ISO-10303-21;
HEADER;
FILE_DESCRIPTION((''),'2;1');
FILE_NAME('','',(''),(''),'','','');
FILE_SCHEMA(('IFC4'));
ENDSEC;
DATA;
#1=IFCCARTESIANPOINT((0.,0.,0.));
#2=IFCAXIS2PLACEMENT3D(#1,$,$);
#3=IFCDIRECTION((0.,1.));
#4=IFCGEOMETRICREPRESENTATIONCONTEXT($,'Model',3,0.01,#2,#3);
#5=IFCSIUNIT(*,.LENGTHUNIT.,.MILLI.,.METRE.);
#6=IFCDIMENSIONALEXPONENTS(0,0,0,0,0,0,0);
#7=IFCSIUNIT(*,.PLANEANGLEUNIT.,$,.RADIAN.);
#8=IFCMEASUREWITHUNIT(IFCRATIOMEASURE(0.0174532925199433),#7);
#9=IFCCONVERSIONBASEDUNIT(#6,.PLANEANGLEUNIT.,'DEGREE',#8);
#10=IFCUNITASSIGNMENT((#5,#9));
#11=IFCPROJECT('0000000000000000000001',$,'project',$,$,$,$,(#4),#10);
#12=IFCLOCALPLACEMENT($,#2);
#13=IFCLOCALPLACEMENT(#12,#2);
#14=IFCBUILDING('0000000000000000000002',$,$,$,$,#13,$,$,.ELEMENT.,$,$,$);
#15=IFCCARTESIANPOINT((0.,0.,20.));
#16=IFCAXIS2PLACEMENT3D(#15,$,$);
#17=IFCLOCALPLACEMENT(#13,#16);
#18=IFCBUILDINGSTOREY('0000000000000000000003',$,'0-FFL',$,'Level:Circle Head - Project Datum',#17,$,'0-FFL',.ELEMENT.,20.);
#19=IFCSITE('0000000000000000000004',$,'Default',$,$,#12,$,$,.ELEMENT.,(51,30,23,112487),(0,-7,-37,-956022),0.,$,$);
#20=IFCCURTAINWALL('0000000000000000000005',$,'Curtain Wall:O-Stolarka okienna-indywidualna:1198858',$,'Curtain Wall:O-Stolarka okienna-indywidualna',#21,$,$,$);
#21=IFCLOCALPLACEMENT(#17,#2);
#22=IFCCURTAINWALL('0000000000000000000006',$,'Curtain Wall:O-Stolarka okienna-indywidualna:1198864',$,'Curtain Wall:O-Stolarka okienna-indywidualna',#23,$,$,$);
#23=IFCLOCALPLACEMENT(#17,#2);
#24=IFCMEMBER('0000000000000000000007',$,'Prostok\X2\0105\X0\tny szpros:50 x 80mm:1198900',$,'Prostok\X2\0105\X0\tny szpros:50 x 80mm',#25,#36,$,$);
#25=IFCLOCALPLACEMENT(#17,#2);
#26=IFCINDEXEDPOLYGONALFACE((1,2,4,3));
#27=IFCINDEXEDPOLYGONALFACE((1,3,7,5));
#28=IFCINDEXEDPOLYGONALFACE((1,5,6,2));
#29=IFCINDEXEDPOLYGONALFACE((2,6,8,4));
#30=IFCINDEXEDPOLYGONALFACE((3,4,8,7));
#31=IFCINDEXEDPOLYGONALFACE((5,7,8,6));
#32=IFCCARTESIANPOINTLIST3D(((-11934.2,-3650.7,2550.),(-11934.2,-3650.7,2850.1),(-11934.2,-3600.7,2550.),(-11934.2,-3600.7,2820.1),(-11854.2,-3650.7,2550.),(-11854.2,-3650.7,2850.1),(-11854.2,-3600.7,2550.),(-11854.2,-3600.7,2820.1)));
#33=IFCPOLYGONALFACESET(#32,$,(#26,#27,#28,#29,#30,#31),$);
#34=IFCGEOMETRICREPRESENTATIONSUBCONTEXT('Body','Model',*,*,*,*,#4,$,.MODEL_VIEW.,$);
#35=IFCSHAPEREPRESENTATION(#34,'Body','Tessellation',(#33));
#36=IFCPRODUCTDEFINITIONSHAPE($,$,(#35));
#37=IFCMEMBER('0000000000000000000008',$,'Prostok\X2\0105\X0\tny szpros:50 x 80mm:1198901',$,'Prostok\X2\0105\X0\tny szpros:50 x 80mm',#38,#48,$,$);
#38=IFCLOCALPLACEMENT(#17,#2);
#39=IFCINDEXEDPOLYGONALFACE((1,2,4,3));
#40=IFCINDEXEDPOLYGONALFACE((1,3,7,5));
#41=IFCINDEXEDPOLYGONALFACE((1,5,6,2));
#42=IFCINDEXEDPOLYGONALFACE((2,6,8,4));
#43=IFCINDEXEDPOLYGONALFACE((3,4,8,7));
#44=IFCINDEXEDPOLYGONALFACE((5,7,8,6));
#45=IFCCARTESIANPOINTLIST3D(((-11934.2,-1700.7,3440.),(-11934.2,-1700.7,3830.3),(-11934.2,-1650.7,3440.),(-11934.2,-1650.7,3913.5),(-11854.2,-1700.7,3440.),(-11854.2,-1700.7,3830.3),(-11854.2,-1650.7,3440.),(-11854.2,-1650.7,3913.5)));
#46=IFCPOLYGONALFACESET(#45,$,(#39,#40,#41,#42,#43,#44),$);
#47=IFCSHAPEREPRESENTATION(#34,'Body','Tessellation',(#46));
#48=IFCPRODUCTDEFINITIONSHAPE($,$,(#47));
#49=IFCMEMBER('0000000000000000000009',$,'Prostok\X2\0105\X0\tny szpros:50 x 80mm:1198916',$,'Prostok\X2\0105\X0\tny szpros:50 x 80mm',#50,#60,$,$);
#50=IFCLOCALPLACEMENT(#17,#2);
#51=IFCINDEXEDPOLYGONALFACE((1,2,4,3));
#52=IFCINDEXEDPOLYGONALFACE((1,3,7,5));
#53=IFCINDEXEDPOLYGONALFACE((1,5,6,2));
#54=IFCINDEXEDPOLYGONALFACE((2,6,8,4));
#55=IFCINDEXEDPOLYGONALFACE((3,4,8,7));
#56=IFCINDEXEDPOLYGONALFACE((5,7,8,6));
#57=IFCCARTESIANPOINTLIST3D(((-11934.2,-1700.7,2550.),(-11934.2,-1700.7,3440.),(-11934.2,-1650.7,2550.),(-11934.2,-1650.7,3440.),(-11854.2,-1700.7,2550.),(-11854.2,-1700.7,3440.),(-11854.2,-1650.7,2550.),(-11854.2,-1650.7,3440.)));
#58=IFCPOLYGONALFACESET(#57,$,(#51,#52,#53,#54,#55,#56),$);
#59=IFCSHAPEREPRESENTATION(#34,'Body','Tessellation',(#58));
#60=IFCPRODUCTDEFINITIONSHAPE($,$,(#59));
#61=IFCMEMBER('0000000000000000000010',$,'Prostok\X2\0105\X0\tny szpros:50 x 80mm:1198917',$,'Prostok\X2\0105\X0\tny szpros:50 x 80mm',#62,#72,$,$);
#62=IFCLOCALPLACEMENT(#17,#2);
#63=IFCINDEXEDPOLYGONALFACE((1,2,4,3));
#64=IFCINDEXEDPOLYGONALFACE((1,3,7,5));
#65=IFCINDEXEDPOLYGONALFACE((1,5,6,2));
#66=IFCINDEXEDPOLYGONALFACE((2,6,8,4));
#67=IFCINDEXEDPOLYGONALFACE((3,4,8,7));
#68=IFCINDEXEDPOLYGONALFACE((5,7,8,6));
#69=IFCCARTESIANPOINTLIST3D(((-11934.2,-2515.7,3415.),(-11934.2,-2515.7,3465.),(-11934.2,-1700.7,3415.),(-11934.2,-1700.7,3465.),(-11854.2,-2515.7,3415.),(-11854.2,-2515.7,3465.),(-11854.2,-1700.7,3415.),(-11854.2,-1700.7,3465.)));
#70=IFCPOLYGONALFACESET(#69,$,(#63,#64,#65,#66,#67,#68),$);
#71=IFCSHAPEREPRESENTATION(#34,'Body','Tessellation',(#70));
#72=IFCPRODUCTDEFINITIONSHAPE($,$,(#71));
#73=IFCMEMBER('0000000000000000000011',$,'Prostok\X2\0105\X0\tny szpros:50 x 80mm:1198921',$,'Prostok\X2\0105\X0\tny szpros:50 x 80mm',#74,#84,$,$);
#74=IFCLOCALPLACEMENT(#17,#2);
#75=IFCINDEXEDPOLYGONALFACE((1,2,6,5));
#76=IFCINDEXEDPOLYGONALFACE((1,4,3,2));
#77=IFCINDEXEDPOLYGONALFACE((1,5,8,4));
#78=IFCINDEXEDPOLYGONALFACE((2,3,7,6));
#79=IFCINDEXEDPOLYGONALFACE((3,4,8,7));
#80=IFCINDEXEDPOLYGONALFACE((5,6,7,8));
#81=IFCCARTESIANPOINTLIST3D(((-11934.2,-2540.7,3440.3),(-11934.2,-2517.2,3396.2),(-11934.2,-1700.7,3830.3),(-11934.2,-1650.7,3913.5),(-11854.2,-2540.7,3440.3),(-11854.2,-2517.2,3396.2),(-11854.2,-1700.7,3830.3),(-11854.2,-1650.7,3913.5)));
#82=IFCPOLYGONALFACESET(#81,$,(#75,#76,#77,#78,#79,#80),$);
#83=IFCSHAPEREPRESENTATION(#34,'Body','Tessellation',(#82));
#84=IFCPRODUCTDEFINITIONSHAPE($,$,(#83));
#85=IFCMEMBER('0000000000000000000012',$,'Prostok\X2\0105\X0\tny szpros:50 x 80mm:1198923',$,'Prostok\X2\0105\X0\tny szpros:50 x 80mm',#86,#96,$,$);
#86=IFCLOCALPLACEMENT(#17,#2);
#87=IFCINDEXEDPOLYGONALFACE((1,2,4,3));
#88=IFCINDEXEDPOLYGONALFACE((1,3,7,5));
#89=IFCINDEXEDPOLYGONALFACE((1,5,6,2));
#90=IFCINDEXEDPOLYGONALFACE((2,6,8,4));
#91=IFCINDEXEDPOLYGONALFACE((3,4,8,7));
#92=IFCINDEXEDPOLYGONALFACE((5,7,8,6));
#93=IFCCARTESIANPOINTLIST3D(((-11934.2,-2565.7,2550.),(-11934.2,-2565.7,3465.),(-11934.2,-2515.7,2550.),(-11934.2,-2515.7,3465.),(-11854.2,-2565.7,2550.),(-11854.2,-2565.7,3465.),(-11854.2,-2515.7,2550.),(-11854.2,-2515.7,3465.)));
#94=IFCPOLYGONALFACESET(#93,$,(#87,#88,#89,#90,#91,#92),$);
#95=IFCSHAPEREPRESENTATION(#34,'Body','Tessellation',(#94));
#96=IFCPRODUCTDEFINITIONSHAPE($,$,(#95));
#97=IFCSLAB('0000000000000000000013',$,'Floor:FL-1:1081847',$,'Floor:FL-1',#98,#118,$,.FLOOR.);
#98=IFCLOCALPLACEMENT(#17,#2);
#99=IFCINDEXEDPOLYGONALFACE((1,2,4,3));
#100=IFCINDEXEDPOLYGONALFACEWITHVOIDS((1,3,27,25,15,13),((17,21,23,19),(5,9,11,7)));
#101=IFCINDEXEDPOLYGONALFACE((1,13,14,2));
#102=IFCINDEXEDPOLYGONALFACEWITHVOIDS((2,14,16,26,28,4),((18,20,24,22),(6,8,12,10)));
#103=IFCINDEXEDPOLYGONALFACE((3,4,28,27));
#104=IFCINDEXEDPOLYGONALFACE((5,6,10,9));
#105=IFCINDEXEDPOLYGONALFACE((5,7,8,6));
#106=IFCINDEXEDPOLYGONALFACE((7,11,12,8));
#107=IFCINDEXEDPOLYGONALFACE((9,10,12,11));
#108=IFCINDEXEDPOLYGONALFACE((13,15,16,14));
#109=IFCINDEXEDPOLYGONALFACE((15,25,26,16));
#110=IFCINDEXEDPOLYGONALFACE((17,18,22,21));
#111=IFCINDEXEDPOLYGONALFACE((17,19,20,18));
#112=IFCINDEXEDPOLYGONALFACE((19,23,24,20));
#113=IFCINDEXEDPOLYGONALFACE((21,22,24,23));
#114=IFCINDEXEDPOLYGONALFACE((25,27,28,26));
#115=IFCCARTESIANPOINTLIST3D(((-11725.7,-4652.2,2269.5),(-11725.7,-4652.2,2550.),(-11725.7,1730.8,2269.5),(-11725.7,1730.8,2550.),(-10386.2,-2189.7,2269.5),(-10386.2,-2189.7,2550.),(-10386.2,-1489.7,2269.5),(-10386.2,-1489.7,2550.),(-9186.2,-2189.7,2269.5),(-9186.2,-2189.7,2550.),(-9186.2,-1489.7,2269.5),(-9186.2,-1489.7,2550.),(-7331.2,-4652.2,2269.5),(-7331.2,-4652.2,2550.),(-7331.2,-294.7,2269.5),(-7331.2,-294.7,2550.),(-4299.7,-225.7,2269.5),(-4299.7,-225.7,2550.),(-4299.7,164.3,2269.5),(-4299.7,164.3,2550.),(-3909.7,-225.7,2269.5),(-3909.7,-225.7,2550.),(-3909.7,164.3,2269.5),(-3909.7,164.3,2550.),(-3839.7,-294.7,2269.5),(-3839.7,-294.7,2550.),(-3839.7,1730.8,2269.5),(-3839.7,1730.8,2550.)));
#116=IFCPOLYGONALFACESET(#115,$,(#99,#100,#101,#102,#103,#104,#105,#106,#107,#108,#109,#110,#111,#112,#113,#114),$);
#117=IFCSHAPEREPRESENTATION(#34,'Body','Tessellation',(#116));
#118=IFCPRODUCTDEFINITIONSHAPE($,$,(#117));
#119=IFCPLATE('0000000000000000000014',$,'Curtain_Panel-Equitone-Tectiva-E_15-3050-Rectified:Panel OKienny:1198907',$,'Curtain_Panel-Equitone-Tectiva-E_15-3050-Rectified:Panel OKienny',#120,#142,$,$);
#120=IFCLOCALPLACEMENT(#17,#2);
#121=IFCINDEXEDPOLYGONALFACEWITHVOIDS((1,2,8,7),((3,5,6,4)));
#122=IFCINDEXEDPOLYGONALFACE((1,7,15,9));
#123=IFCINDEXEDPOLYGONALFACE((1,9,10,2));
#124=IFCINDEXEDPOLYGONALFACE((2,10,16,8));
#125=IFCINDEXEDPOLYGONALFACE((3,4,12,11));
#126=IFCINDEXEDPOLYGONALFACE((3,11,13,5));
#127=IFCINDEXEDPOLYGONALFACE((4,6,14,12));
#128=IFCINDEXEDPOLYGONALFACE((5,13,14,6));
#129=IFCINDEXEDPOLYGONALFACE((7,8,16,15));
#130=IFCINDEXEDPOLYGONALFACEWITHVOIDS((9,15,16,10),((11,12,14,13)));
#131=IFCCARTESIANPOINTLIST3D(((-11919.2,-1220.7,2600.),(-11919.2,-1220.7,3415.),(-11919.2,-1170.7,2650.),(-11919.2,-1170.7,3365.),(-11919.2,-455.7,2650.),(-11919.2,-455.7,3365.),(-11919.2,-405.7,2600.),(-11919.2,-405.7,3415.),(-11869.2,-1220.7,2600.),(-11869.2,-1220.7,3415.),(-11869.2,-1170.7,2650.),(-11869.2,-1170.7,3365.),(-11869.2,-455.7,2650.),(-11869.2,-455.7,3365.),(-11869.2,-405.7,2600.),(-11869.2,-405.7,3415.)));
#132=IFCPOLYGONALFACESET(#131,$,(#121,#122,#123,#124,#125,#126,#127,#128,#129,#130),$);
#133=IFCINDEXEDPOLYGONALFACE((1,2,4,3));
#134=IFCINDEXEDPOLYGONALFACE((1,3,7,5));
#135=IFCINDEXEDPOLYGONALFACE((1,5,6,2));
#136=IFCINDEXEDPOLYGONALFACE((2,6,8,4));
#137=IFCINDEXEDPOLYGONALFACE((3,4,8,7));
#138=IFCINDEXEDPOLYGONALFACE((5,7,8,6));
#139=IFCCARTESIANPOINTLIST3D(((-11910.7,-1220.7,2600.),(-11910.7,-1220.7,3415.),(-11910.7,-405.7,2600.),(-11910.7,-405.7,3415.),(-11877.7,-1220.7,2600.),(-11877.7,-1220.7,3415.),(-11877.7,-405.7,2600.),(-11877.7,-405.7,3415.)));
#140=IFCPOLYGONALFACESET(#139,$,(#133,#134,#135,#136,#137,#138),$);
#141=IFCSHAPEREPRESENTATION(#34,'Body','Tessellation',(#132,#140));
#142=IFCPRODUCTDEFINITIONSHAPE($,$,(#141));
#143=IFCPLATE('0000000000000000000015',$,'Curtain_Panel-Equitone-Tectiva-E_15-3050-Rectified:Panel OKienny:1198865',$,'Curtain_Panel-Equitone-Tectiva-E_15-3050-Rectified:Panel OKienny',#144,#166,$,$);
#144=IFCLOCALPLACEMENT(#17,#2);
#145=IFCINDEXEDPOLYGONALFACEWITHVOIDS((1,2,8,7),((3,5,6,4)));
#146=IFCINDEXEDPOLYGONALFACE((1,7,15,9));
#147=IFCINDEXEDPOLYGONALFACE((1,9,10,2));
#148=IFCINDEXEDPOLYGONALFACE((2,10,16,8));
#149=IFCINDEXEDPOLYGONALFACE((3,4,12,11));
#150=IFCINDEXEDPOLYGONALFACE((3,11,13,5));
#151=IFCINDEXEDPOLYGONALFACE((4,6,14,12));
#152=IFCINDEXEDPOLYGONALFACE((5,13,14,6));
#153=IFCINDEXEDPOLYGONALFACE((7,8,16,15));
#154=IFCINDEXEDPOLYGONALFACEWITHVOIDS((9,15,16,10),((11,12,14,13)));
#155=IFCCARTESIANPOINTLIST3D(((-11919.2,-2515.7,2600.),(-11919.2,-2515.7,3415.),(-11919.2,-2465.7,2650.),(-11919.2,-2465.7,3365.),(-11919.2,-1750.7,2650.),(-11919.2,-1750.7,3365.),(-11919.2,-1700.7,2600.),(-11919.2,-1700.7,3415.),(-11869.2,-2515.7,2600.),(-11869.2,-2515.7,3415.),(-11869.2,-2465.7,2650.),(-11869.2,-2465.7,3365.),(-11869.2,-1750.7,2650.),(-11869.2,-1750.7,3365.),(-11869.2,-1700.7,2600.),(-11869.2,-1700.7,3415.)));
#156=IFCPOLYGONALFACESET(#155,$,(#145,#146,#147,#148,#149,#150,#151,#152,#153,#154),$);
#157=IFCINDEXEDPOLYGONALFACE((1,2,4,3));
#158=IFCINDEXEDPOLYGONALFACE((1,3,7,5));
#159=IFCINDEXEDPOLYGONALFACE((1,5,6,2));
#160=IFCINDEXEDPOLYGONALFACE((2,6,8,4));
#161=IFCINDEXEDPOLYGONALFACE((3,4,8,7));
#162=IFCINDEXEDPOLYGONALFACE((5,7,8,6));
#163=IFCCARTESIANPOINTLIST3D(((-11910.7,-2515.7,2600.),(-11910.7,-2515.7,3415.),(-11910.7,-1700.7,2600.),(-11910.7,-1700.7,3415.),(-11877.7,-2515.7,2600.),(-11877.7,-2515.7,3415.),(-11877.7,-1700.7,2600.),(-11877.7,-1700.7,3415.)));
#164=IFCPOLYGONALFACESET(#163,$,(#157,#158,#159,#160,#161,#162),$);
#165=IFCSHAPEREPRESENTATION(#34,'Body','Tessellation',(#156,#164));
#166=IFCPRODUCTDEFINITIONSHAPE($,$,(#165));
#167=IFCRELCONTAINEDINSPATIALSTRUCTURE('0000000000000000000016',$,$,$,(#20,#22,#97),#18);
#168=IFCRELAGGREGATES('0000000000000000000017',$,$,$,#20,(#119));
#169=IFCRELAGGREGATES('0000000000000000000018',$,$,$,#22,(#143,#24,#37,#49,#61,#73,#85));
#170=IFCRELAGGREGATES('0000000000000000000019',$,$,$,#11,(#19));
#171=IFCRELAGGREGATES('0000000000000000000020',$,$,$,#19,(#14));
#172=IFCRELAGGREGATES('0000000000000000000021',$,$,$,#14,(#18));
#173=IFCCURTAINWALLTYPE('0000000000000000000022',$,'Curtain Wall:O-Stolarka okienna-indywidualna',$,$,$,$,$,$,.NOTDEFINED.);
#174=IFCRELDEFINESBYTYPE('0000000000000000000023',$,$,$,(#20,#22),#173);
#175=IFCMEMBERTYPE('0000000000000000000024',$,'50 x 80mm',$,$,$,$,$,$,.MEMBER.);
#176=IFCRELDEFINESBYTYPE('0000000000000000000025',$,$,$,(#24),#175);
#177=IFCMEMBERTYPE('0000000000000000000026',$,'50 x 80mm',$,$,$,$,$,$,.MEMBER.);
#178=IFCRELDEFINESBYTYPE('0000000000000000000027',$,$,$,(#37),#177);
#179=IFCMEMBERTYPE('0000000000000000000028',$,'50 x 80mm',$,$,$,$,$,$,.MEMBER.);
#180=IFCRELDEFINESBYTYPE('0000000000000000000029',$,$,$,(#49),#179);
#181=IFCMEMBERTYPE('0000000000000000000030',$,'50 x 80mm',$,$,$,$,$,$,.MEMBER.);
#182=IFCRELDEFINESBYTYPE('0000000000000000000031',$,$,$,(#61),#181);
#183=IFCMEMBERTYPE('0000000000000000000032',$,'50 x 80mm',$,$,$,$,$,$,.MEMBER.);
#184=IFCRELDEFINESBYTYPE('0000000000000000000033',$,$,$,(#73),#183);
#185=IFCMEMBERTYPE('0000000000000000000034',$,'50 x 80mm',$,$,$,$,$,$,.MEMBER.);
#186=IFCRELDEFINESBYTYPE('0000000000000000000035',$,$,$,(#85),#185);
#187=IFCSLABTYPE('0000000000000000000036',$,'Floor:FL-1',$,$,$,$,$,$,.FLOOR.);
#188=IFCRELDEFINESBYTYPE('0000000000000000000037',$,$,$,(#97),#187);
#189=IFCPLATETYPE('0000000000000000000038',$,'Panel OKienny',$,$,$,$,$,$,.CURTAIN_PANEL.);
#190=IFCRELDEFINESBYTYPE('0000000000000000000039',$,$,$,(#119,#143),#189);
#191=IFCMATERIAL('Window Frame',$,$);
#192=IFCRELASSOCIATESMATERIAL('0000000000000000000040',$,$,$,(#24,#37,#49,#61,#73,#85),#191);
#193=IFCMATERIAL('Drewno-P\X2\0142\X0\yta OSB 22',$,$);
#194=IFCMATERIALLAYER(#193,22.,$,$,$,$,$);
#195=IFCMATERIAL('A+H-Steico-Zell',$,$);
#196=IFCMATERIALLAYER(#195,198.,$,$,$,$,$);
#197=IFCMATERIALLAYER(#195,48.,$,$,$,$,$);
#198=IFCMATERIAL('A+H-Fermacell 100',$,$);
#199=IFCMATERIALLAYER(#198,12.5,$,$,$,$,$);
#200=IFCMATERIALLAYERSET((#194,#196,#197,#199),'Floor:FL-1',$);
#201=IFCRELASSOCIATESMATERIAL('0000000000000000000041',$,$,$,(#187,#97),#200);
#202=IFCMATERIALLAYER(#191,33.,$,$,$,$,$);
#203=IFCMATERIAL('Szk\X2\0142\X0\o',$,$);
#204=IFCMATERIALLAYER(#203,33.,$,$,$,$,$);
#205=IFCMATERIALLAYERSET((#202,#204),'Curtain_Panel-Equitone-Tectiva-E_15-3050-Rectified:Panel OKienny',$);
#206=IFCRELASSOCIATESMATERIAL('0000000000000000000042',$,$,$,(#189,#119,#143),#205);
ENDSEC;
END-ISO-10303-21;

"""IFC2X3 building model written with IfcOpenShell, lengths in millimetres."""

from ifc_helpers import new_model, entity, si_unit, converted_unit, direction, frame, origin, origin_2d_with_axis, place, context, subcontext, project, spatial, polyline, rectangle, outline, extrude, clip, halfspace, source, transform, mapped, material, layer, layer_set, layer_usage, type_object, type_shapes, element, aggregate, save


model = new_model("IFC2X3")

# Units and contexts
model_context = context("Model", 3, precision=0.01, world=origin(), true_north=direction((0.0, 1.0)))
body_context = subcontext(model_context, "Body", "Model", "MODEL_VIEW")
ifc_project = project(units=[si_unit("LENGTHUNIT", "METRE", prefix="MILLI"), converted_unit("PLANEANGLEUNIT", "DEGREE", entity("IfcRatioMeasure", 0.0174532925199433), si_unit("PLANEANGLEUNIT", "RADIAN"), dimensions=[0, 0, 0, 0, 0, 0, 0])], contexts=[model_context])

# Site, building, storey
site_placement = place(None, origin())
site = spatial("IfcSite", under=ifc_project, at=site_placement, Name="Default", CompositionType="ELEMENT", RefLatitude=(51, 30, 23, 112487), RefLongitude=(0, -7, -37, -956022), RefElevation=0.0)
building_placement = place(site_placement, origin())
building = spatial("IfcBuilding", under=site, at=building_placement, CompositionType="ELEMENT")
storey_placement = place(building_placement, frame((0.0, 0.0, 20.0)))
storey = spatial("IfcBuildingStorey", under=building, at=storey_placement, Name="0-FFL", ObjectType="Level:Circle Head - Project Datum", LongName="0-FFL", CompositionType="ELEMENT", Elevation=20.0)

# Curtain wall
curtain_wall_type = type_object("IfcCurtainWallType", Name="Curtain Wall:O-Stolarka okienna-indywidualna", PredefinedType="NOTDEFINED")
curtain_wall_1_placement = place(storey_placement, frame((0.0, 0.0, -20.0)))
curtain_wall_1 = element("IfcCurtainWall", 1, at=curtain_wall_1_placement, inside=storey, type_object=curtain_wall_type, Name="Curtain Wall:O-Stolarka okienna-indywidualna:1198858", ObjectType="Curtain Wall:O-Stolarka okienna-indywidualna")
ifc_material_1 = material(Name="Window Frame")
placement = place(building_placement, origin())

# Curtain wall
curtain_wall_2_placement = place(storey_placement, frame((0.0, 0.0, -20.0)))
curtain_wall_2 = element("IfcCurtainWall", 2, at=curtain_wall_2_placement, inside=storey, type_object=curtain_wall_type, Name="Curtain Wall:O-Stolarka okienna-indywidualna:1198864", ObjectType="Curtain Wall:O-Stolarka okienna-indywidualna")

# Members
member_type_1 = type_object("IfcMemberType", Name="50 x 80mm", PredefinedType="MEMBER")
shared_shape_1 = source(origin(), body_context, "Body", "Clipping", [
    clip(extrude(rectangle(XDim=80.0, YDim=50.0, at=origin_2d_with_axis()), frame((-25.0, 0.0, -300.1), z_axis=(0.0, 0.0, 1.0), x_axis=(0.0, -1.0, 0.0)), (0.0, 0.0, 1.0), 300.1), halfspace(frame((0.0, -304.8, -300.1), z_axis=(-0.515038, 0.0, -0.857167), x_axis=(-0.857167, 0.0, 0.515038)), False)),
])
type_shapes(member_type_1, [shared_shape_1])
member_1_placement = place(placement, frame((-11894.2, -3650.7, 2570.0), z_axis=(0.0, 0.0, -1.0), x_axis=(0.0, -1.0, 0.0)))
member_1 = element("IfcMember", 3, at=member_1_placement, type_object=member_type_1, material=ifc_material_1, Name="Prostokątny szpros:50 x 80mm:1198900", ObjectType="Prostokątny szpros:50 x 80mm", context=body_context, shape_type="MappedRepresentation", body=[
    mapped(shared_shape_1, transform((0.0, 0.0, 0.0), scale=1.0)),
])
member_type_2 = type_object("IfcMemberType", Name="50 x 80mm", PredefinedType="MEMBER")
shared_shape_2 = source(origin(), body_context, "Body", "Clipping", [
    clip(extrude(rectangle(XDim=80.0, YDim=50.0, at=origin_2d_with_axis()), frame((-25.0, 0.0, -473.5), z_axis=(0.0, 0.0, 1.0), x_axis=(0.0, -1.0, 0.0)), (0.0, 0.0, 1.0), 473.5), halfspace(frame((0.0, -304.8, 0.0), z_axis=(-0.857167, 0.0, 0.515038), x_axis=(-0.515038, 0.0, -0.857167)), False)),
])
type_shapes(member_type_2, [shared_shape_2])
member_2_placement = place(placement, frame((-11894.2, -1650.7, 3933.5), z_axis=(0.0, 0.0, 1.0), x_axis=(0.0, 1.0, 0.0)))
member_2 = element("IfcMember", 4, at=member_2_placement, type_object=member_type_2, material=ifc_material_1, Name="Prostokątny szpros:50 x 80mm:1198901", ObjectType="Prostokątny szpros:50 x 80mm", context=body_context, shape_type="MappedRepresentation", body=[
    mapped(shared_shape_2, transform((0.0, 0.0, 0.0), scale=1.0)),
])
member_type_3 = type_object("IfcMemberType", Name="50 x 80mm", PredefinedType="MEMBER")
shared_shape_3 = source(origin(), body_context, "Body", "SweptSolid", [
    extrude(rectangle(XDim=80.0, YDim=50.0, at=origin_2d_with_axis()), frame((-25.0, 0.0, -890.0), z_axis=(0.0, 0.0, 1.0), x_axis=(0.0, -1.0, 0.0)), (0.0, 0.0, 1.0), 890.0),
])
type_shapes(member_type_3, [shared_shape_3])
member_3_placement = place(placement, frame((-11894.2, -1650.7, 3460.0), z_axis=(0.0, 0.0, 1.0), x_axis=(0.0, 1.0, 0.0)))
member_3 = element("IfcMember", 5, at=member_3_placement, type_object=member_type_3, material=ifc_material_1, Name="Prostokątny szpros:50 x 80mm:1198916", ObjectType="Prostokątny szpros:50 x 80mm", context=body_context, shape_type="MappedRepresentation", body=[
    mapped(shared_shape_3, transform((0.0, 0.0, 0.0), scale=1.0)),
])
member_type_4 = type_object("IfcMemberType", Name="50 x 80mm", PredefinedType="MEMBER")
shared_shape_4 = source(origin(), body_context, "Body", "SweptSolid", [
    extrude(rectangle(XDim=80.0, YDim=50.0, at=origin_2d_with_axis()), frame((0.0, 0.0, -815.0), z_axis=(0.0, 0.0, 1.0), x_axis=(0.0, -1.0, 0.0)), (0.0, 0.0, 1.0), 815.0),
])
type_shapes(member_type_4, [shared_shape_4])
member_4_placement = place(placement, frame((-11894.2, -2515.7, 3460.0), z_axis=(0.0, -1.0, 0.0), x_axis=(0.0, 0.0, 1.0)))
member_4 = element("IfcMember", 6, at=member_4_placement, type_object=member_type_4, material=ifc_material_1, Name="Prostokątny szpros:50 x 80mm:1198917", ObjectType="Prostokątny szpros:50 x 80mm", context=body_context, shape_type="MappedRepresentation", body=[
    mapped(shared_shape_4, transform((0.0, 0.0, 0.0), scale=1.0)),
])
member_type_5 = type_object("IfcMemberType", Name="50 x 80mm", PredefinedType="MEMBER")
shared_shape_5 = source(origin(), body_context, "Body", "Clipping", [
    clip(extrude(rectangle(XDim=80.0, YDim=50.0, at=origin_2d_with_axis()), frame((-25.0, 0.0, -1008.0), z_axis=(0.0, 0.0, 1.0), x_axis=(0.0, -1.0, 0.0)), (0.0, 0.0, 1.0), 1008.0), halfspace(frame((0.0, -304.8, -1008.0), z_axis=(-0.857167, 0.0, -0.515038), x_axis=(-0.515038, 0.0, 0.857167)), False)),
])
type_shapes(member_type_5, [shared_shape_5])
member_5_placement = place(placement, frame((-11894.2, -2540.7, 3460.3), z_axis=(0.0, -0.882948, -0.469472), x_axis=(0.0, -0.469472, 0.882948)))
member_5 = element("IfcMember", 7, at=member_5_placement, type_object=member_type_5, material=ifc_material_1, Name="Prostokątny szpros:50 x 80mm:1198921", ObjectType="Prostokątny szpros:50 x 80mm", context=body_context, shape_type="MappedRepresentation", body=[
    mapped(shared_shape_5, transform((0.0, 0.0, 0.0), scale=1.0)),
])
member_type_6 = type_object("IfcMemberType", Name="50 x 80mm", PredefinedType="MEMBER")
shared_shape_6 = source(origin(), body_context, "Body", "SweptSolid", [
    extrude(rectangle(XDim=80.0, YDim=50.0, at=origin_2d_with_axis()), frame((0.0, 0.0, -915.0), z_axis=(0.0, 0.0, 1.0), x_axis=(0.0, -1.0, 0.0)), (0.0, 0.0, 1.0), 915.0),
])
type_shapes(member_type_6, [shared_shape_6])
member_6_placement = place(placement, frame((-11894.2, -2540.7, 2570.0), z_axis=(0.0, 0.0, -1.0), x_axis=(0.0, -1.0, 0.0)))
member_6 = element("IfcMember", 8, at=member_6_placement, type_object=member_type_6, material=ifc_material_1, Name="Prostokątny szpros:50 x 80mm:1198923", ObjectType="Prostokątny szpros:50 x 80mm", context=body_context, shape_type="MappedRepresentation", body=[
    mapped(shared_shape_6, transform((0.0, 0.0, 0.0), scale=1.0)),
])

# Slab, openings
ifc_material_2 = material(Name="Drewno-Płyta OSB 22")
ifc_layer_1 = layer(ifc_material_2, 22.0)
ifc_material_3 = material(Name="A+H-Steico-Zell")
ifc_layer_2 = layer(ifc_material_3, 198.0)
ifc_layer_3 = layer(ifc_material_3, 48.0)
ifc_material_4 = material(Name="A+H-Fermacell 100")
ifc_layer_4 = layer(ifc_material_4, 12.5)
ifc_layer_set_1 = layer_set([ifc_layer_1, ifc_layer_2, ifc_layer_3, ifc_layer_4], Name="Floor:FL-1")
ifc_layer_usage_1 = layer_usage(ifc_layer_set_1, "AXIS3", "POSITIVE", 0.0)
slab_type = type_object("IfcSlabType", Name="Floor:FL-1", PredefinedType="FLOOR", material=ifc_layer_set_1)
slab_placement = place(storey_placement, frame((-11725.7, -4652.2, 2269.5)))
slab = element("IfcSlab", 9, at=slab_placement, inside=storey, type_object=slab_type, material=ifc_layer_usage_1, Name="Floor:FL-1:1081847", ObjectType="Floor:FL-1", PredefinedType="FLOOR", context=body_context, shape_type="SweptSolid", body=[
    extrude(outline(polyline([(-3943.0, 3191.5), (-3943.0, 1166.0), (-451.5, 1166.0), (-451.5, -3191.5), (3943.0, -3191.5), (3943.0, 3191.5), (-3943.0, 3191.5)])), frame((3943.0, 3191.5, 280.5), z_axis=(0.0, 0.0, -1.0), x_axis=(-1.0, 0.0, 0.0)), (0.0, 0.0, 1.0), 280.5),
])
opening_1_placement = place(slab_placement, frame((7621.0, 4621.5, 280.5)))
element("IfcOpeningElement", 10, at=opening_1_placement, cuts=slab, ObjectType="Opening", context=body_context, shape_type="SweptSolid", body=[
    extrude(rectangle(XDim=390.0, YDim=390.0, at=origin_2d_with_axis()), frame((0.0, 0.0, 0.0), z_axis=(0.0, 0.0, -1.0), x_axis=(0.0, -1.0, 0.0)), (0.0, 0.0, 1.0), 280.5),
])
opening_2_placement = place(slab_placement, frame((1939.5, 2812.5, 280.5)))
element("IfcOpeningElement", 11, at=opening_2_placement, cuts=slab, ObjectType="Opening", context=body_context, shape_type="SweptSolid", body=[
    extrude(rectangle(XDim=700.0, YDim=1200.0, at=origin_2d_with_axis()), frame((0.0, 0.0, 0.0), z_axis=(0.0, 0.0, 1.0), x_axis=(0.0, -1.0, 0.0)), (0.0, 0.0, -1.0), 280.5),
])

# Plates
ifc_layer_5 = layer(ifc_material_1, 33.0)
ifc_material_5 = material(Name="Szkło")
ifc_layer_6 = layer(ifc_material_5, 33.0)
ifc_layer_set_2 = layer_set([ifc_layer_5, ifc_layer_6], Name="Curtain_Panel-Equitone-Tectiva-E_15-3050-Rectified:Panel OKienny")
ifc_layer_usage_2 = layer_usage(ifc_layer_set_2, "AXIS3", "POSITIVE", 0.0)
plate_type = type_object("IfcPlateType", Name="Panel OKienny", PredefinedType="CURTAIN_PANEL", material=ifc_layer_set_2)
shared_shape_7 = source(origin(), body_context, "Body", "SweptSolid", [
    extrude(outline(polyline([(-407.5, -407.5), (407.5, -407.5), (407.5, 407.5), (-407.5, 407.5), (-407.5, -407.5)]), holes=[polyline([(357.5, -357.5), (-357.5, -357.5), (-357.5, 357.5), (357.5, 357.5), (357.5, -357.5)])]), frame((0.0, -25.0, 407.5), z_axis=(0.0, 1.0, 0.0), x_axis=(0.0, 0.0, 1.0)), (0.0, 0.0, 1.0), 50.0),
    extrude(rectangle(XDim=815.0, YDim=33.0, at=origin_2d_with_axis()), frame((0.0, 0.0, 0.0), z_axis=(0.0, 0.0, 1.0), x_axis=(-1.0, 0.0, 0.0)), (0.0, 0.0, 1.0), 815.0),
])
type_shapes(plate_type, [shared_shape_7])
plate_1_placement = place(curtain_wall_1_placement, frame((-11894.2, -813.2, 2620.0), z_axis=(0.0, 0.0, 1.0), x_axis=(0.0, -1.0, 0.0)))
plate_1 = element("IfcPlate", 12, at=plate_1_placement, type_object=plate_type, material=ifc_layer_usage_2, Name="Curtain_Panel-Equitone-Tectiva-E_15-3050-Rectified:Panel OKienny:1198907", ObjectType="Curtain_Panel-Equitone-Tectiva-E_15-3050-Rectified:Panel OKienny", context=body_context, shape_type="MappedRepresentation", body=[
    mapped(shared_shape_7, transform((0.0, 0.0, 0.0), scale=1.0)),
])
aggregate(curtain_wall_1, [plate_1])
ifc_layer_usage_3 = layer_usage(ifc_layer_set_2, "AXIS3", "POSITIVE", 0.0)
plate_2_placement = place(curtain_wall_2_placement, frame((-11894.2, -2108.2, 2620.0), z_axis=(0.0, 0.0, 1.0), x_axis=(0.0, -1.0, 0.0)))
plate_2 = element("IfcPlate", 13, at=plate_2_placement, type_object=plate_type, material=ifc_layer_usage_3, Name="Curtain_Panel-Equitone-Tectiva-E_15-3050-Rectified:Panel OKienny:1198865", ObjectType="Curtain_Panel-Equitone-Tectiva-E_15-3050-Rectified:Panel OKienny", context=body_context, shape_type="MappedRepresentation", body=[
    mapped(shared_shape_7, transform((0.0, 0.0, 0.0), scale=1.0)),
])
aggregate(curtain_wall_2, [plate_2, member_1, member_2, member_3, member_4, member_5, member_6])

save(model, "model.ifc")
